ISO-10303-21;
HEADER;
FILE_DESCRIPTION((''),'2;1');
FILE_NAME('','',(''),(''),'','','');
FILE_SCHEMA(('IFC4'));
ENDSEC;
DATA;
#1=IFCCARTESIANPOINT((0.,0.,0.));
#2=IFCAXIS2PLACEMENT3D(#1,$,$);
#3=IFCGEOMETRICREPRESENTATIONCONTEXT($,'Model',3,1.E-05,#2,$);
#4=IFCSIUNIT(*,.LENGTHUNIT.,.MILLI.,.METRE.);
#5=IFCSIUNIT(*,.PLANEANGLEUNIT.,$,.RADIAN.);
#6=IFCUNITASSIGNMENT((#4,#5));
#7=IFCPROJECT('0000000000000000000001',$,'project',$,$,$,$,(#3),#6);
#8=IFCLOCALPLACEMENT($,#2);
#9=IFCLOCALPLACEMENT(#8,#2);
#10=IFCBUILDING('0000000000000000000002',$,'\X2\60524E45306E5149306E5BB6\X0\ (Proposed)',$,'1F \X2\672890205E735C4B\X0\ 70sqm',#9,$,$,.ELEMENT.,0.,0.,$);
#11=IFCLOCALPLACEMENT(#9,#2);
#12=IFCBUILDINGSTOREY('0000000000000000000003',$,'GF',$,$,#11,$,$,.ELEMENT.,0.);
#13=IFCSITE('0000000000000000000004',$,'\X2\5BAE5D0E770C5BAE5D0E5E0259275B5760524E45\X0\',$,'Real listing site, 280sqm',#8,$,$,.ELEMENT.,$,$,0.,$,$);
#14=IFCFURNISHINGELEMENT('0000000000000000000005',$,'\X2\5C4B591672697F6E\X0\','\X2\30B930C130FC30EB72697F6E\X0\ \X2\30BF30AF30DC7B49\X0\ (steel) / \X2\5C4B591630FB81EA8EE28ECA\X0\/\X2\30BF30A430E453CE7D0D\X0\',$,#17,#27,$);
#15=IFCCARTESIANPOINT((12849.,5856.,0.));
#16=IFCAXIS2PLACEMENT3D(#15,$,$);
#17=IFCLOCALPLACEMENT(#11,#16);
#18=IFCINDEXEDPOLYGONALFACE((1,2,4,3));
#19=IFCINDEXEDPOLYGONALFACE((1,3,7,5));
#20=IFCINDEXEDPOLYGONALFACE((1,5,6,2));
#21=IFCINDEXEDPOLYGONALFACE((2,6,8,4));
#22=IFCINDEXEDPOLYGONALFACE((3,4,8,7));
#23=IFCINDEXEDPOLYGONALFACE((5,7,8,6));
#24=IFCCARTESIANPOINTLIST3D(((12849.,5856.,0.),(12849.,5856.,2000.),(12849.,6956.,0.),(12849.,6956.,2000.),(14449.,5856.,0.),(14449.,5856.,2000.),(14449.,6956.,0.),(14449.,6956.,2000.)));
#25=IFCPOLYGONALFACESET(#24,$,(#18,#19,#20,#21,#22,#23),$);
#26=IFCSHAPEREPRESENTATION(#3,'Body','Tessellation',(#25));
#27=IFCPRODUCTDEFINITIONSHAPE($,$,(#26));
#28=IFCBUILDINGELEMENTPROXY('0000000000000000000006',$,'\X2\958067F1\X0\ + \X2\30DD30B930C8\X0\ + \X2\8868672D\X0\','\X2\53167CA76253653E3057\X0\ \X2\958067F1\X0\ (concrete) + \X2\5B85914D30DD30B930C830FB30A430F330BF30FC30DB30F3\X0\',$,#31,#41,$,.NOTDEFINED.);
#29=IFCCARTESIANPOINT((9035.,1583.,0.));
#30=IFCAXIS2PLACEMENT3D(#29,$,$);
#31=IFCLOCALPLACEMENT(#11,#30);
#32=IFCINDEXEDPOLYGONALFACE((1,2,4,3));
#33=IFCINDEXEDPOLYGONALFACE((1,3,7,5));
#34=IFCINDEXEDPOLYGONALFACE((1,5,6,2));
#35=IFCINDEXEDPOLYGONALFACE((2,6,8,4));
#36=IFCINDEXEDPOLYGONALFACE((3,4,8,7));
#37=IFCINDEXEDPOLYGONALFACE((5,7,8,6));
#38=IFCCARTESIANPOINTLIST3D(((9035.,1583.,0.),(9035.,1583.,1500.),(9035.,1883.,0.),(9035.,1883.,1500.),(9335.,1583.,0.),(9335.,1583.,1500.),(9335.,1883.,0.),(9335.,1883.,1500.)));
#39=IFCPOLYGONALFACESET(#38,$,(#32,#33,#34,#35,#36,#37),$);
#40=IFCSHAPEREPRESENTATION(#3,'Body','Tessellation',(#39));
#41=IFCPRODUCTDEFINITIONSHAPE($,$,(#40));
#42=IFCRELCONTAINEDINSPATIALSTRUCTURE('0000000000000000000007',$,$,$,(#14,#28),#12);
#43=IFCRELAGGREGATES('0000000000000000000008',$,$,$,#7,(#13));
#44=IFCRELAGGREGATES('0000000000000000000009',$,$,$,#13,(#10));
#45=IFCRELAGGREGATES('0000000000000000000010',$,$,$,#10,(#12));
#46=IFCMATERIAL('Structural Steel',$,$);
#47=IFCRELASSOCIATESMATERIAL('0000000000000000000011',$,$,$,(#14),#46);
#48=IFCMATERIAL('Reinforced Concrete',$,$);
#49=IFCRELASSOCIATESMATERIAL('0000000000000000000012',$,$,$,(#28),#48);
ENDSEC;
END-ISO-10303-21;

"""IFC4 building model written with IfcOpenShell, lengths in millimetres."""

from ifc_helpers import new_model, si_unit, frame, frame_2d, origin, place, context, project, spatial, rectangle, extrude, material, element, save


model = new_model("IFC4")

# Units and contexts
model_context = context("Model", 3, precision=1e-05, world=origin())
ifc_project = project(units=[si_unit("LENGTHUNIT", "METRE", prefix="MILLI"), si_unit("PLANEANGLEUNIT", "RADIAN")], contexts=[model_context])

# Site, building, storey
site_placement = place(None, origin())
site = spatial("IfcSite", under=ifc_project, at=site_placement, Name="宮崎県宮崎市大字恒久", ObjectType="Real listing site, 280sqm", CompositionType="ELEMENT", RefElevation=0.0)
building_placement = place(site_placement, origin())
building = spatial("IfcBuilding", under=site, at=building_placement, Name="恒久の光の家 (Proposed)", ObjectType="1F 木造平屋 70sqm", CompositionType="ELEMENT", ElevationOfRefHeight=0.0, ElevationOfTerrain=0.0)
storey_placement = place(building_placement, origin())
storey = spatial("IfcBuildingStorey", under=building, at=storey_placement, Name="GF", CompositionType="ELEMENT", Elevation=0.0)

# Shared definitions
ifc_material_1 = material(Name="Reinforced Concrete")

# Shared definitions
ifc_material_2 = material(Name="Structural Steel")

# Furnishing element
furnishing_1_placement = place(storey_placement, frame((12849.0, 5856.0, 0.0)))
element("IfcFurnishingElement", 1, at=furnishing_1_placement, inside=storey, material=ifc_material_2, Name="屋外物置", Description="スチール物置 タクボ等 (steel) / 屋外・自転車/タイヤ収納", context=model_context, shape_type="SweptSolid", body=[
    extrude(rectangle(XDim=1600.0, YDim=1100.0, at=frame_2d((800.0, 550.0))), frame((12849.0, 5856.0, 0.0)), (0.0, 0.0, 1.0), 2000.0),
])

# Building element proxy
proxy_placement = place(storey_placement, frame((9035.0, 1583.0, 0.0)))
element("IfcBuildingElementProxy", 2, at=proxy_placement, inside=storey, material=ifc_material_1, Name="門柱 + ポスト + 表札", Description="化粧打放し 門柱 (concrete) + 宅配ポスト・インターホン", PredefinedType="NOTDEFINED", context=model_context, shape_type="SweptSolid", body=[
    extrude(rectangle(XDim=300.0, YDim=300.0, at=frame_2d((150.0, 150.0))), frame((9035.0, 1583.0, 0.0)), (0.0, 0.0, 1.0), 1500.0),
])

save(model, "model.ifc")
